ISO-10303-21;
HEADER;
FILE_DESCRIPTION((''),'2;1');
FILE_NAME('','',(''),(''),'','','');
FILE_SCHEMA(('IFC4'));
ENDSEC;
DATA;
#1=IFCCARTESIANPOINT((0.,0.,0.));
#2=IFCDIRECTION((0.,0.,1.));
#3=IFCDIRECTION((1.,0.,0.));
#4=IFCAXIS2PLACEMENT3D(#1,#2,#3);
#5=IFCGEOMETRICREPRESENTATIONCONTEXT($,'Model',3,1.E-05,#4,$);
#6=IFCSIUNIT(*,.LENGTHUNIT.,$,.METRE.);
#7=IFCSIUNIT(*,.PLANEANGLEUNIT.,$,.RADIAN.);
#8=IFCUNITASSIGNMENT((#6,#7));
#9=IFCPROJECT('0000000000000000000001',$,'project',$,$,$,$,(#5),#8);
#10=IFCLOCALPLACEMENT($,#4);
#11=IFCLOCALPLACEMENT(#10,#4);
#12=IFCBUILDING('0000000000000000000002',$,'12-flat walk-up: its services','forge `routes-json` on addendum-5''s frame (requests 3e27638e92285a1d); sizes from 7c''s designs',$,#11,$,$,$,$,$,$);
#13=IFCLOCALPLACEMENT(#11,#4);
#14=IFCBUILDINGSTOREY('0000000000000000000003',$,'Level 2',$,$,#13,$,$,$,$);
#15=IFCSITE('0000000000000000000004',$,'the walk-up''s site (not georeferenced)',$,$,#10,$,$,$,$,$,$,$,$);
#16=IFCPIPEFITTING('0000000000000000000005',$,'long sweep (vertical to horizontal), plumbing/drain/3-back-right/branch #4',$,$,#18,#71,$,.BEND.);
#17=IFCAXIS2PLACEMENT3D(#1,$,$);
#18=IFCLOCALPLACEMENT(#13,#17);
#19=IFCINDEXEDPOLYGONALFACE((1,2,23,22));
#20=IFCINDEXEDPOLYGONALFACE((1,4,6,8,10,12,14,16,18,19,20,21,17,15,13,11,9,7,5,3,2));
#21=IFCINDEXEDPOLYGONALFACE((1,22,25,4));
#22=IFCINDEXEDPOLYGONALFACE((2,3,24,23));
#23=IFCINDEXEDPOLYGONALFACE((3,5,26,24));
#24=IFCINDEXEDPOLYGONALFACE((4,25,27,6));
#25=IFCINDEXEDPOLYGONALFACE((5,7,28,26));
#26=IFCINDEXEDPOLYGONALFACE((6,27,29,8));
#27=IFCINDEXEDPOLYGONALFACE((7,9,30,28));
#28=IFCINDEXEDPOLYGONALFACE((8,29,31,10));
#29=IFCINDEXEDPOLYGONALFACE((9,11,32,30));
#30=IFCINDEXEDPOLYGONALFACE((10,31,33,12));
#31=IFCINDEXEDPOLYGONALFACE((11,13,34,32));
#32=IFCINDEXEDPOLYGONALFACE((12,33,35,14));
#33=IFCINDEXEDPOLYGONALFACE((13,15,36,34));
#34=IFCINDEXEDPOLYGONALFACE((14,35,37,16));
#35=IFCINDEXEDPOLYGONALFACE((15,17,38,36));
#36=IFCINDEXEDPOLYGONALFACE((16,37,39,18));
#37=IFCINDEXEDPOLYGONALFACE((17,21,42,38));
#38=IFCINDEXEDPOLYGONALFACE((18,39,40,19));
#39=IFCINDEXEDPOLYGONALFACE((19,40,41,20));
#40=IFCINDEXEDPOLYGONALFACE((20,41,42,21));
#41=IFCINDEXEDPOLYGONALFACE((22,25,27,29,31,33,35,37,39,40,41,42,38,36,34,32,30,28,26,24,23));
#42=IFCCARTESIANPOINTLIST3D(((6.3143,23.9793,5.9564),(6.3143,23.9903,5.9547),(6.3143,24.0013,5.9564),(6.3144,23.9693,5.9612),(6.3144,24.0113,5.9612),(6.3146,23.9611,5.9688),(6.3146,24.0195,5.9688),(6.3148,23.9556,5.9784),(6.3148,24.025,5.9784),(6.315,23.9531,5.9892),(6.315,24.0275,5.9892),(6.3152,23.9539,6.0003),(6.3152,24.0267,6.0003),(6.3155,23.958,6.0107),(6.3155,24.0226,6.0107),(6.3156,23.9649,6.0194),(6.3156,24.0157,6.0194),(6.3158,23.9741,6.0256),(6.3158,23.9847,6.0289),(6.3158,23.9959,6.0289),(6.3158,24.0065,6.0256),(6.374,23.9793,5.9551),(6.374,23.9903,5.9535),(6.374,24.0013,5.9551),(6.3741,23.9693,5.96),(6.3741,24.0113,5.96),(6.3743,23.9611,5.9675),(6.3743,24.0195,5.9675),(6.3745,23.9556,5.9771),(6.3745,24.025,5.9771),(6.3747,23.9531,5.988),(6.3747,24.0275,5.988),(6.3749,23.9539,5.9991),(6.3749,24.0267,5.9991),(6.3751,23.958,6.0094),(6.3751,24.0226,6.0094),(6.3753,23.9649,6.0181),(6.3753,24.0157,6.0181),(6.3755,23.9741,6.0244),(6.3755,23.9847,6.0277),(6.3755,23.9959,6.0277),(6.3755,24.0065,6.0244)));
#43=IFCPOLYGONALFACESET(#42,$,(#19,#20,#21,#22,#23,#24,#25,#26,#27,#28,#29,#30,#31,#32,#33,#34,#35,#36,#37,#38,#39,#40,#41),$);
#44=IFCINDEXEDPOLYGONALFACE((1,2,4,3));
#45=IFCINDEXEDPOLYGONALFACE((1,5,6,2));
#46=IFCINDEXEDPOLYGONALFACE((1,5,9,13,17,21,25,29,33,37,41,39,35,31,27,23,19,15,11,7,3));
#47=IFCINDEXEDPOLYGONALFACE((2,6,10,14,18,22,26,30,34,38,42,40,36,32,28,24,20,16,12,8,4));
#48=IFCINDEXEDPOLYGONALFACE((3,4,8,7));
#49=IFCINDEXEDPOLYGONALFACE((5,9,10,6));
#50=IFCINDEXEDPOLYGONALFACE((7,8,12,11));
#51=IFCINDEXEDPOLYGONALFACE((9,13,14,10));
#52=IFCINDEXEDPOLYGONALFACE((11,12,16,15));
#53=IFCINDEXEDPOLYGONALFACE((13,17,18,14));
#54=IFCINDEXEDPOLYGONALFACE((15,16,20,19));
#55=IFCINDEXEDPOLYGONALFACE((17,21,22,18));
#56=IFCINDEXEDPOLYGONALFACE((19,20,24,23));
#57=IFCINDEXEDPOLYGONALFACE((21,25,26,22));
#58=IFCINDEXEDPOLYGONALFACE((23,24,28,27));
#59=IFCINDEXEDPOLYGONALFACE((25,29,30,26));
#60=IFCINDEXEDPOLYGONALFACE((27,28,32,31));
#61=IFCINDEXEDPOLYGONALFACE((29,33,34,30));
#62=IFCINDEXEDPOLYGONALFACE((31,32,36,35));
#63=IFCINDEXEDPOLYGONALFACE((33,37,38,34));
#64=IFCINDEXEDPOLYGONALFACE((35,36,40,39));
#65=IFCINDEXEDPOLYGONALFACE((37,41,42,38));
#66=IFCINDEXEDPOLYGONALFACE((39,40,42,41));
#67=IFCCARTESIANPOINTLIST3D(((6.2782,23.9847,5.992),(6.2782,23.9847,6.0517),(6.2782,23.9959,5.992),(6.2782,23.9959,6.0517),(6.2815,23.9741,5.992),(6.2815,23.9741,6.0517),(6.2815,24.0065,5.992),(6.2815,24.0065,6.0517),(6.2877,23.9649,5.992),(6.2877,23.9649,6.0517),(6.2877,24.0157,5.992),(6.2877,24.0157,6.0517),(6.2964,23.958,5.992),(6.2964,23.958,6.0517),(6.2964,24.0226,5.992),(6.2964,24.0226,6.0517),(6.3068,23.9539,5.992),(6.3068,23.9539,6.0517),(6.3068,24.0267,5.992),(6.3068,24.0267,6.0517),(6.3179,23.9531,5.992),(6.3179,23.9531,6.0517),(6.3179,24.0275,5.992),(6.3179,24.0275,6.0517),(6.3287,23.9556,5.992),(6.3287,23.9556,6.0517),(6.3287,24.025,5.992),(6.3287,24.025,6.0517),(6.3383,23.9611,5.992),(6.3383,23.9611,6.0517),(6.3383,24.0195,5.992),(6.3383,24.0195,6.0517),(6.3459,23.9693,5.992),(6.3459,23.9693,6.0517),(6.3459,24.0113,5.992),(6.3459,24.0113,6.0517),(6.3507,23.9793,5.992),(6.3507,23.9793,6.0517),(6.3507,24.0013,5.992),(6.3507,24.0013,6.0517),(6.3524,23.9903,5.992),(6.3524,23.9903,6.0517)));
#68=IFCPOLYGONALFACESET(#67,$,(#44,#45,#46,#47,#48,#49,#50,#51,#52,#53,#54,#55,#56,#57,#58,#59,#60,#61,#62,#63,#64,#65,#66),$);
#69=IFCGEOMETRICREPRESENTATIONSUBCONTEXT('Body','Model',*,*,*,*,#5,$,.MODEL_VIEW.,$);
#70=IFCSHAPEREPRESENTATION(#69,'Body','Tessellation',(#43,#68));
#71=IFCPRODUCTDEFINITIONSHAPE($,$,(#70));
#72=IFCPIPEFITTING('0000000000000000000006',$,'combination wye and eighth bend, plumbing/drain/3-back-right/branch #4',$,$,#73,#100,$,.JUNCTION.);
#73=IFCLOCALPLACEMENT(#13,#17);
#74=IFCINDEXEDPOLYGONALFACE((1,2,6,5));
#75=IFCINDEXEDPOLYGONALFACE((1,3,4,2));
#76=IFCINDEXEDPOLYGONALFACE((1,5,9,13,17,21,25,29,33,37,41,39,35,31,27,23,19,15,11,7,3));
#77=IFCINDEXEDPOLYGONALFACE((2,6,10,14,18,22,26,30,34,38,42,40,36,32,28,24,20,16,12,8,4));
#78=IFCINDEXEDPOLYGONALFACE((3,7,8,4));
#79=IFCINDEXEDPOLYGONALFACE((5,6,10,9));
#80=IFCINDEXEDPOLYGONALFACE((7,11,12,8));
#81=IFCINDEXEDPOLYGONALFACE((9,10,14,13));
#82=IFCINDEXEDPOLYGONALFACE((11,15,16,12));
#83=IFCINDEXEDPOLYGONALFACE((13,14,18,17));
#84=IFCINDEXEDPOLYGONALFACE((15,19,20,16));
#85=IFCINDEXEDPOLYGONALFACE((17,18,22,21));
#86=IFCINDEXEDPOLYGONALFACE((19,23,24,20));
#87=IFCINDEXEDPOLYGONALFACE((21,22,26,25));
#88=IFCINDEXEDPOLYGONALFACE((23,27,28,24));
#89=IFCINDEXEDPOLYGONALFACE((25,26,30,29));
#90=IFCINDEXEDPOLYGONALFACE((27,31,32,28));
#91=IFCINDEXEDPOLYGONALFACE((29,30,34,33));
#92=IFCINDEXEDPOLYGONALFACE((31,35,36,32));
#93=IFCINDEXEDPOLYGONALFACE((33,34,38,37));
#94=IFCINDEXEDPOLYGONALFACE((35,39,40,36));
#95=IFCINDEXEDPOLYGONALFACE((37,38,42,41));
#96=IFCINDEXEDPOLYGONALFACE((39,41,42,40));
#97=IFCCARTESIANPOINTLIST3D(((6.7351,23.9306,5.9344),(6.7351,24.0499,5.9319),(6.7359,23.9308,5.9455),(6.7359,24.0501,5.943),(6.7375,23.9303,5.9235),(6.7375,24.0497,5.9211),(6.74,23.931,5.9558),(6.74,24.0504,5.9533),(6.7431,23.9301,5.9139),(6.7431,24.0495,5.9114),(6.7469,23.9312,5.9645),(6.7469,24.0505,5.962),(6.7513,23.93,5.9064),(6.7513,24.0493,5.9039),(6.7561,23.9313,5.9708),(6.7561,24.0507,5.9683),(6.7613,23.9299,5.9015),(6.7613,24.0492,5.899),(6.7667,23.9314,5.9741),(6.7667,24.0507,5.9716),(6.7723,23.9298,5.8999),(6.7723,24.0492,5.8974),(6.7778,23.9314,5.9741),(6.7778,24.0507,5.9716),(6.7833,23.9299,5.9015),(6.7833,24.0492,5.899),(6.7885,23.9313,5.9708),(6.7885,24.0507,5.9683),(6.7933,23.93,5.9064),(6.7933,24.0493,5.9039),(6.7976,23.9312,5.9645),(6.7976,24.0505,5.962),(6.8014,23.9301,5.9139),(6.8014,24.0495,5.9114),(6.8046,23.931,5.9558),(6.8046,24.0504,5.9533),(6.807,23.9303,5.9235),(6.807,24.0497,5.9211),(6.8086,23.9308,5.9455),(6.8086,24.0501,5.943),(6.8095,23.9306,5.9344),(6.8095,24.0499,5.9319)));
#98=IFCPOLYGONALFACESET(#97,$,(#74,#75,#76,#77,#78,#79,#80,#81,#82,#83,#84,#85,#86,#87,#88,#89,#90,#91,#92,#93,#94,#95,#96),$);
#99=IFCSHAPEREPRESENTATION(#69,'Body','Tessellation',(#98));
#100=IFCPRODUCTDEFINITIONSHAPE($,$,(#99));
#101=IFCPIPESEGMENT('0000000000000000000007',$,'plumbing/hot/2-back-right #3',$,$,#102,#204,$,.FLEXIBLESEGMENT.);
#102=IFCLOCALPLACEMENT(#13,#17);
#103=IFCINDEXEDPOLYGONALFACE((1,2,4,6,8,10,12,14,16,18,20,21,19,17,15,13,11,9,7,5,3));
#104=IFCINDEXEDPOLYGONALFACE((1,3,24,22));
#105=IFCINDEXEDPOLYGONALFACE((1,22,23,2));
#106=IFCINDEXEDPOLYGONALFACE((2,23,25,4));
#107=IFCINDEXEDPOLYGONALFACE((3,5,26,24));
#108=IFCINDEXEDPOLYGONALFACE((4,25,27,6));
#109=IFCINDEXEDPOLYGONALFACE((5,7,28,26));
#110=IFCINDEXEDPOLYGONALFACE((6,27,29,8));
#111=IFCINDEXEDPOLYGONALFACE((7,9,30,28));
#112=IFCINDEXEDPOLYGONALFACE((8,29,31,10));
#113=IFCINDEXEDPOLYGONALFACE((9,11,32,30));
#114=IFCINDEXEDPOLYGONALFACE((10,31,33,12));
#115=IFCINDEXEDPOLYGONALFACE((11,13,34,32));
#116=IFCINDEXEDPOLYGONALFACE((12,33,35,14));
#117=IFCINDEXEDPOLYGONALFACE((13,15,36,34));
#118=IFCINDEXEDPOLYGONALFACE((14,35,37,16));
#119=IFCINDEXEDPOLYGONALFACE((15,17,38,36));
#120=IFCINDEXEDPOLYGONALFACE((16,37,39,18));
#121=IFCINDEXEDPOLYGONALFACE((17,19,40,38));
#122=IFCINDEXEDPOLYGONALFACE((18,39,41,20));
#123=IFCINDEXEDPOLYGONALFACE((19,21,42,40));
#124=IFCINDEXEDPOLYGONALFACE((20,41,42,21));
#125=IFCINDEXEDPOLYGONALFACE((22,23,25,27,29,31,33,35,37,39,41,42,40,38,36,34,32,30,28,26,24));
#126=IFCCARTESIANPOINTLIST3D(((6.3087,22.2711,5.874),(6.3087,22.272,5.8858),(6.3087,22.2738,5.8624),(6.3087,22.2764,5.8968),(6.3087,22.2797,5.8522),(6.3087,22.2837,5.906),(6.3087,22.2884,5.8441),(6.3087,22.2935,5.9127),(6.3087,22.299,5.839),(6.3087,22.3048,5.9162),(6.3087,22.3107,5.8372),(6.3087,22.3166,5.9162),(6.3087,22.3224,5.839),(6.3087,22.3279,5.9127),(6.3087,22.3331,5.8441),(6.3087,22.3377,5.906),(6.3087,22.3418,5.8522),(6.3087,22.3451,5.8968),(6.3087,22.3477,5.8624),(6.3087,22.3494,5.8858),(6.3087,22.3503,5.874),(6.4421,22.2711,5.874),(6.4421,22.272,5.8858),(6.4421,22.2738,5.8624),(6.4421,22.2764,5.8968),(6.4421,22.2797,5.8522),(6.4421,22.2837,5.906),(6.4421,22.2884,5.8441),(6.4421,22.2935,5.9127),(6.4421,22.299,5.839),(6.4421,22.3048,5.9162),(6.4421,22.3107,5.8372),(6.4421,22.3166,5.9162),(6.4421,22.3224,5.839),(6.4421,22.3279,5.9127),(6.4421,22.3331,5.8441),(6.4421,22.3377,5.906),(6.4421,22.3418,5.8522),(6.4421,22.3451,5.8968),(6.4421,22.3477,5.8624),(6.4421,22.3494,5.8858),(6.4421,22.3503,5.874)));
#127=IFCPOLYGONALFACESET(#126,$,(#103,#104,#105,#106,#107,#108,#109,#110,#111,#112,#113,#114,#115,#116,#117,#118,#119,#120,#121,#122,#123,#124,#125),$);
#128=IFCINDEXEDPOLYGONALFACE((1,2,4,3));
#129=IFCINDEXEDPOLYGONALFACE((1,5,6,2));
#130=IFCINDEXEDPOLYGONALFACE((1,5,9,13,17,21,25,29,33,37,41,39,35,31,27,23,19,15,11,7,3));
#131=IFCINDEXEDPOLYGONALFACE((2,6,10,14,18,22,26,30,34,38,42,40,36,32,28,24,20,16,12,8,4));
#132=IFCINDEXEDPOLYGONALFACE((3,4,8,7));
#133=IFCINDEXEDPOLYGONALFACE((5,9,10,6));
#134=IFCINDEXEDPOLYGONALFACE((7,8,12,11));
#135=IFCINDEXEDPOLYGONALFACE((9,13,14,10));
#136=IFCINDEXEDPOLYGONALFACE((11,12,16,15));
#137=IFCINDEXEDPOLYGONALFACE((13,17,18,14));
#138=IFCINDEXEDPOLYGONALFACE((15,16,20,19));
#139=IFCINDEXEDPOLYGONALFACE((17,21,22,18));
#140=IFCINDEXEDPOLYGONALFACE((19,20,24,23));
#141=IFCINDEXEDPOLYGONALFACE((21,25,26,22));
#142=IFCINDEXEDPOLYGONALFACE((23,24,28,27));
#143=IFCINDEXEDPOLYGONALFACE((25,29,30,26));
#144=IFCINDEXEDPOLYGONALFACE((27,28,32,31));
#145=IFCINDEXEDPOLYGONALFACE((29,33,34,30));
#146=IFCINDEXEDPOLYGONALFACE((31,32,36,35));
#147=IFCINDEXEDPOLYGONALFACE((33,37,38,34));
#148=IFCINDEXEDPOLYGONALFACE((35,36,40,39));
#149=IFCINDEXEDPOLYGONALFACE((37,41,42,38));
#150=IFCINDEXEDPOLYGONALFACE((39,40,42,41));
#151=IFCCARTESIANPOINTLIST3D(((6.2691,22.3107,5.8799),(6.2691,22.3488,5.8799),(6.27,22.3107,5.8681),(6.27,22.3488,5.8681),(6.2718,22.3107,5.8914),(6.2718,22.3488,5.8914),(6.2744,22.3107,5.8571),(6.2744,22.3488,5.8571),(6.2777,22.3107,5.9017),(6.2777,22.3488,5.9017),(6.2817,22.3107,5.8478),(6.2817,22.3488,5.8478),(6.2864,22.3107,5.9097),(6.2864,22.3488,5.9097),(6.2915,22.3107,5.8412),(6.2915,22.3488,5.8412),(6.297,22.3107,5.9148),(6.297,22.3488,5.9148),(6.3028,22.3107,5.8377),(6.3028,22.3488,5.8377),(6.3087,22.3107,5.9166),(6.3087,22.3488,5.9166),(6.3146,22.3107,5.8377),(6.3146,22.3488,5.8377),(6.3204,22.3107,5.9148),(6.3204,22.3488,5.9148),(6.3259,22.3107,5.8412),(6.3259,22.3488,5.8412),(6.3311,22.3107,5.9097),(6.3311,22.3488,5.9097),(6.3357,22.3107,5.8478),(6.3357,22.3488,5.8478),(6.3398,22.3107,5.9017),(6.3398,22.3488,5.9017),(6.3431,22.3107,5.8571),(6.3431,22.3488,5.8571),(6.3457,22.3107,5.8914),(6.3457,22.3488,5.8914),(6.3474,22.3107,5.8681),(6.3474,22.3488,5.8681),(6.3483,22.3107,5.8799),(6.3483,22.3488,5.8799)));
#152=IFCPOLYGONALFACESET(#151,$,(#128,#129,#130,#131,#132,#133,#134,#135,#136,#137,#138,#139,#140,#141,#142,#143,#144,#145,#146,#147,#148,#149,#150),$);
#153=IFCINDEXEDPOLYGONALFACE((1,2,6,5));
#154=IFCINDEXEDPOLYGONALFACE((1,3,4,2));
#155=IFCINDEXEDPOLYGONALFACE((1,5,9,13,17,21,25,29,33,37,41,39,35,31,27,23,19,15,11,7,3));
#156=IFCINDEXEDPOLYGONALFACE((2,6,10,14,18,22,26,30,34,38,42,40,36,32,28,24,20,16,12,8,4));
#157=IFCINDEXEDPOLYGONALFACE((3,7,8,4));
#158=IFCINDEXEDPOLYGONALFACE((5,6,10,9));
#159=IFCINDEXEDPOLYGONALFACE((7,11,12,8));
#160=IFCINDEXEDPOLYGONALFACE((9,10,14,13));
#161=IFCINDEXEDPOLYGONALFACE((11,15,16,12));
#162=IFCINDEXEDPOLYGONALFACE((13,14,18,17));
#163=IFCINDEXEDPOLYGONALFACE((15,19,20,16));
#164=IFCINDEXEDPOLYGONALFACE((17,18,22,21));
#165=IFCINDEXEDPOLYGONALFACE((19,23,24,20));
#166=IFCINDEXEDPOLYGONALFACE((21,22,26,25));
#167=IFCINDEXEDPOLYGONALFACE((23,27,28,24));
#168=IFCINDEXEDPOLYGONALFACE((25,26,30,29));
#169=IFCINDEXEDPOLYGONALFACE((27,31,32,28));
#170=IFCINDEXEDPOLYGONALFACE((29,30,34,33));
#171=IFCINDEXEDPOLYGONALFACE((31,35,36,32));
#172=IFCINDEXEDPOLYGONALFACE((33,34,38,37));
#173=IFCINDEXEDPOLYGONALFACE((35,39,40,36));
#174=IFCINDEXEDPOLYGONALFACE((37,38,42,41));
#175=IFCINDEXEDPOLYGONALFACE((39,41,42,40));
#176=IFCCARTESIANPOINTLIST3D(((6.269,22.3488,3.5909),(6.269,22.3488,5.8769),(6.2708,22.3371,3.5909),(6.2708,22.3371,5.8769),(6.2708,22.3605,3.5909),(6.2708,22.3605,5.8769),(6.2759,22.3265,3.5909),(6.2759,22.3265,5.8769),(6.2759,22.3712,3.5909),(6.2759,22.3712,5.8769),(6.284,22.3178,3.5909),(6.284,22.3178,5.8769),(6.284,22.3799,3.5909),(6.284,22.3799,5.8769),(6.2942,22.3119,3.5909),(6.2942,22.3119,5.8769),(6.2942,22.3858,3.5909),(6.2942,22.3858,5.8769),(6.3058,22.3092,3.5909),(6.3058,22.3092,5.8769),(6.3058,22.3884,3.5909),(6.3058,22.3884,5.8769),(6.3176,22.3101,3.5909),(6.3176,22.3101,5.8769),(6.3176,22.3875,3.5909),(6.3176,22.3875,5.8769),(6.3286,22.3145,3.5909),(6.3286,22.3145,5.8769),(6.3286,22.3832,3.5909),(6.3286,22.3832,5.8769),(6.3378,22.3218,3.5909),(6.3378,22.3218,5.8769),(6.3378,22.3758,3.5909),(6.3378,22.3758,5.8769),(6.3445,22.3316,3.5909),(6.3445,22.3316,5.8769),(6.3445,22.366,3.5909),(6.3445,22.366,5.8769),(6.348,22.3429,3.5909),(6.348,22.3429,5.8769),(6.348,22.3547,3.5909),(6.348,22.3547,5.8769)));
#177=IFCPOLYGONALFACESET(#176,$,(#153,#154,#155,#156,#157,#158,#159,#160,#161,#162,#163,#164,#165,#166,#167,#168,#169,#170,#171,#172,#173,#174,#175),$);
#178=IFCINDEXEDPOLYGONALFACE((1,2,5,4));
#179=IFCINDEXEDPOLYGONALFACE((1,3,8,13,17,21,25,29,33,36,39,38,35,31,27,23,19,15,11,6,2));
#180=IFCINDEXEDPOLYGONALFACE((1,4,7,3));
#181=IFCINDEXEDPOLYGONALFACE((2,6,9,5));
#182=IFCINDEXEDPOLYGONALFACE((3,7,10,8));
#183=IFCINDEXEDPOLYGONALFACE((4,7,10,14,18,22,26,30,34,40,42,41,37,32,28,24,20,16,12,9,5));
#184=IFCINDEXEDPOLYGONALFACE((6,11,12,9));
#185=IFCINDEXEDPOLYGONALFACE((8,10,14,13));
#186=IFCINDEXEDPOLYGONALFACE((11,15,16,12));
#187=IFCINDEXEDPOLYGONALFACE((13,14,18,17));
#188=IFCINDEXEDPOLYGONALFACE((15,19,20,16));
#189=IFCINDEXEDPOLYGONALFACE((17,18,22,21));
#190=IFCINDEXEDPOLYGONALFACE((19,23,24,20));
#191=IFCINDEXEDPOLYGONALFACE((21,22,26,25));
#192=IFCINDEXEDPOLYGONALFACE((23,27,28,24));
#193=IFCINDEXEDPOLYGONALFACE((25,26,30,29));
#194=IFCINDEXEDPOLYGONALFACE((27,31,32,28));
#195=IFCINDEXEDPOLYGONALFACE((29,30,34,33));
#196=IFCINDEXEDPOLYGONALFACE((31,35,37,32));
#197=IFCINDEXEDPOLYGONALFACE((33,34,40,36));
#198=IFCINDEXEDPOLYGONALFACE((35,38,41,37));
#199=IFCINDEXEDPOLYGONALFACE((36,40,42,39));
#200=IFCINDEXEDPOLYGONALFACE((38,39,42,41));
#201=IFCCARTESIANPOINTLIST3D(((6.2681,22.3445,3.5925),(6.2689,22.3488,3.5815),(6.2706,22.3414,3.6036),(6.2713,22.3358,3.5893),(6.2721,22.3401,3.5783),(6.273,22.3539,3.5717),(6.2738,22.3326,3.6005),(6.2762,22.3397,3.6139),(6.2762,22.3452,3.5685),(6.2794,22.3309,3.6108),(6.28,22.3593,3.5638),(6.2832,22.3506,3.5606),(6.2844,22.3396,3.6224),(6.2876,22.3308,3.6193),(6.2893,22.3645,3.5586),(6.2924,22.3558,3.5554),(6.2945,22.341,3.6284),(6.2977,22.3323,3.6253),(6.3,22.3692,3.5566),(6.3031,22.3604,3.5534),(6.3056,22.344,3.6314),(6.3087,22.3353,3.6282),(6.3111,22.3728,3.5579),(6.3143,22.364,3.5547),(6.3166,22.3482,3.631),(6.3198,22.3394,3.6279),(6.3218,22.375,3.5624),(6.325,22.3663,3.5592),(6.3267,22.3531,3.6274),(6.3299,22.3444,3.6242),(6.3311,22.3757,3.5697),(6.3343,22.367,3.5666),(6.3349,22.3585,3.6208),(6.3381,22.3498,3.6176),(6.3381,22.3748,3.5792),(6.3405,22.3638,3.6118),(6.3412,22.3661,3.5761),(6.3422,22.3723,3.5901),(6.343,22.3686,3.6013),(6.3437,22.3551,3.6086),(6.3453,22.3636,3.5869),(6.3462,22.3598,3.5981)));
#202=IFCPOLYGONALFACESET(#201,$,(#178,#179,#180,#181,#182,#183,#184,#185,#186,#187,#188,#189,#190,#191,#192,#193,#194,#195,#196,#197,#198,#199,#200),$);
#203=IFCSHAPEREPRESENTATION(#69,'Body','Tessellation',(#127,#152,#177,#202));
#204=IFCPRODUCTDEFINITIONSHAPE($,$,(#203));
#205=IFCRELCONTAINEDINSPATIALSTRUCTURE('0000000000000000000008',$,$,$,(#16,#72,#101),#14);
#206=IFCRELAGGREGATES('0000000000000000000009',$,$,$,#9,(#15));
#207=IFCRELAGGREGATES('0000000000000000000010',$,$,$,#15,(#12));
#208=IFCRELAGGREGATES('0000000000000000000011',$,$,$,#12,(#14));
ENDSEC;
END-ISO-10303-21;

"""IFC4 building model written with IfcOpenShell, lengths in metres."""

from ifc_helpers import new_model, entity, si_unit, frame, origin_with_axes, place, context, subcontext, project, spatial, element, save


model = new_model("IFC4")

# Units and contexts
model_context = context("Model", 3, precision=1e-05, world=origin_with_axes())
body_context = subcontext(model_context, "Body", "Model", "MODEL_VIEW")
ifc_project = project(units=[si_unit("LENGTHUNIT", "METRE"), si_unit("PLANEANGLEUNIT", "RADIAN")], contexts=[model_context])

# Site, building, storey
site_placement = place(None, origin_with_axes())
site = spatial("IfcSite", under=ifc_project, at=site_placement, Name="the walk-up's site (not georeferenced)")
building_placement = place(site_placement, origin_with_axes())
building = spatial("IfcBuilding", under=site, at=building_placement, Name="12-flat walk-up: its services", Description="forge `routes-json` on addendum-5's frame (requests 3e27638e92285a1d); sizes from 7c's designs")
storey_placement = place(building_placement, origin_with_axes())
storey = spatial("IfcBuildingStorey", under=building, at=storey_placement, Name="Level 2")

# Pipe fittings
pipe_fitting_1_placement = place(storey_placement, frame((6.3748, 23.9903, 5.9908), z_axis=(0.0, 0.0, 1.0), x_axis=(1.0, 0.0, 0.0)))
element("IfcPipeFitting", 1, at=pipe_fitting_1_placement, inside=storey, Name="long sweep (vertical to horizontal), plumbing/drain/3-back-right/branch #4", PredefinedType="BEND", context=body_context, shape_type="AdvancedSweptSolid", body=[
    entity("IfcSweptDiskSolid", entity("IfcPolyline", [entity("IfcCartesianPoint", [0.0, 0.0, 0.0]), entity("IfcCartesianPoint", [-0.0597, 0.0, 0.0012])]), 0.0373),
    entity("IfcSweptDiskSolid", entity("IfcPolyline", [entity("IfcCartesianPoint", [-0.0597, 0.0, 0.0012]), entity("IfcCartesianPoint", [-0.0597, 0.0, 0.0609])]), 0.0373),
])
pipe_fitting_2_placement = place(storey_placement, frame((6.7723, 24.05, 5.9347), z_axis=(0.0, 0.0, 1.0), x_axis=(1.0, 0.0, 0.0)))
element("IfcPipeFitting", 2, at=pipe_fitting_2_placement, inside=storey, Name="combination wye and eighth bend, plumbing/drain/3-back-right/branch #4", PredefinedType="JUNCTION", context=body_context, shape_type="AdvancedSweptSolid", body=[
    entity("IfcSweptDiskSolid", entity("IfcPolyline", [entity("IfcCartesianPoint", [0.0, 0.0, 0.0]), entity("IfcCartesianPoint", [0.0, -0.1194, 0.0025])]), 0.0373),
])

# Pipe segment
pipe_segment_1_placement = place(storey_placement, frame((6.4421, 22.3107, 5.8769), z_axis=(0.0, 0.0, 1.0), x_axis=(1.0, 0.0, 0.0)))
element("IfcPipeSegment", 3, at=pipe_segment_1_placement, inside=storey, Name="plumbing/hot/2-back-right #3", PredefinedType="FLEXIBLESEGMENT", context=body_context, shape_type="AdvancedSweptSolid", body=[
    entity("IfcSweptDiskSolid", entity("IfcPolyline", [entity("IfcCartesianPoint", [0.0, 0.0, 0.0]), entity("IfcCartesianPoint", [-0.1334, 0.0, 0.0])]), 0.0397),
    entity("IfcSweptDiskSolid", entity("IfcPolyline", [entity("IfcCartesianPoint", [-0.1334, 0.0, 0.0]), entity("IfcCartesianPoint", [-0.1334, 0.0381, 0.0])]), 0.0397),
    entity("IfcSweptDiskSolid", entity("IfcPolyline", [entity("IfcCartesianPoint", [-0.1334, 0.0381, 0.0]), entity("IfcCartesianPoint", [-0.1334, 0.0381, -2.286])]), 0.0397),
    entity("IfcSweptDiskSolid", entity("IfcPolyline", [entity("IfcCartesianPoint", [-0.1334, 0.0381, -2.286]), entity("IfcCartesianPoint", [-0.1365, 0.0468, -2.2828])]), 0.0397),
])

save(model, "model.ifc")
